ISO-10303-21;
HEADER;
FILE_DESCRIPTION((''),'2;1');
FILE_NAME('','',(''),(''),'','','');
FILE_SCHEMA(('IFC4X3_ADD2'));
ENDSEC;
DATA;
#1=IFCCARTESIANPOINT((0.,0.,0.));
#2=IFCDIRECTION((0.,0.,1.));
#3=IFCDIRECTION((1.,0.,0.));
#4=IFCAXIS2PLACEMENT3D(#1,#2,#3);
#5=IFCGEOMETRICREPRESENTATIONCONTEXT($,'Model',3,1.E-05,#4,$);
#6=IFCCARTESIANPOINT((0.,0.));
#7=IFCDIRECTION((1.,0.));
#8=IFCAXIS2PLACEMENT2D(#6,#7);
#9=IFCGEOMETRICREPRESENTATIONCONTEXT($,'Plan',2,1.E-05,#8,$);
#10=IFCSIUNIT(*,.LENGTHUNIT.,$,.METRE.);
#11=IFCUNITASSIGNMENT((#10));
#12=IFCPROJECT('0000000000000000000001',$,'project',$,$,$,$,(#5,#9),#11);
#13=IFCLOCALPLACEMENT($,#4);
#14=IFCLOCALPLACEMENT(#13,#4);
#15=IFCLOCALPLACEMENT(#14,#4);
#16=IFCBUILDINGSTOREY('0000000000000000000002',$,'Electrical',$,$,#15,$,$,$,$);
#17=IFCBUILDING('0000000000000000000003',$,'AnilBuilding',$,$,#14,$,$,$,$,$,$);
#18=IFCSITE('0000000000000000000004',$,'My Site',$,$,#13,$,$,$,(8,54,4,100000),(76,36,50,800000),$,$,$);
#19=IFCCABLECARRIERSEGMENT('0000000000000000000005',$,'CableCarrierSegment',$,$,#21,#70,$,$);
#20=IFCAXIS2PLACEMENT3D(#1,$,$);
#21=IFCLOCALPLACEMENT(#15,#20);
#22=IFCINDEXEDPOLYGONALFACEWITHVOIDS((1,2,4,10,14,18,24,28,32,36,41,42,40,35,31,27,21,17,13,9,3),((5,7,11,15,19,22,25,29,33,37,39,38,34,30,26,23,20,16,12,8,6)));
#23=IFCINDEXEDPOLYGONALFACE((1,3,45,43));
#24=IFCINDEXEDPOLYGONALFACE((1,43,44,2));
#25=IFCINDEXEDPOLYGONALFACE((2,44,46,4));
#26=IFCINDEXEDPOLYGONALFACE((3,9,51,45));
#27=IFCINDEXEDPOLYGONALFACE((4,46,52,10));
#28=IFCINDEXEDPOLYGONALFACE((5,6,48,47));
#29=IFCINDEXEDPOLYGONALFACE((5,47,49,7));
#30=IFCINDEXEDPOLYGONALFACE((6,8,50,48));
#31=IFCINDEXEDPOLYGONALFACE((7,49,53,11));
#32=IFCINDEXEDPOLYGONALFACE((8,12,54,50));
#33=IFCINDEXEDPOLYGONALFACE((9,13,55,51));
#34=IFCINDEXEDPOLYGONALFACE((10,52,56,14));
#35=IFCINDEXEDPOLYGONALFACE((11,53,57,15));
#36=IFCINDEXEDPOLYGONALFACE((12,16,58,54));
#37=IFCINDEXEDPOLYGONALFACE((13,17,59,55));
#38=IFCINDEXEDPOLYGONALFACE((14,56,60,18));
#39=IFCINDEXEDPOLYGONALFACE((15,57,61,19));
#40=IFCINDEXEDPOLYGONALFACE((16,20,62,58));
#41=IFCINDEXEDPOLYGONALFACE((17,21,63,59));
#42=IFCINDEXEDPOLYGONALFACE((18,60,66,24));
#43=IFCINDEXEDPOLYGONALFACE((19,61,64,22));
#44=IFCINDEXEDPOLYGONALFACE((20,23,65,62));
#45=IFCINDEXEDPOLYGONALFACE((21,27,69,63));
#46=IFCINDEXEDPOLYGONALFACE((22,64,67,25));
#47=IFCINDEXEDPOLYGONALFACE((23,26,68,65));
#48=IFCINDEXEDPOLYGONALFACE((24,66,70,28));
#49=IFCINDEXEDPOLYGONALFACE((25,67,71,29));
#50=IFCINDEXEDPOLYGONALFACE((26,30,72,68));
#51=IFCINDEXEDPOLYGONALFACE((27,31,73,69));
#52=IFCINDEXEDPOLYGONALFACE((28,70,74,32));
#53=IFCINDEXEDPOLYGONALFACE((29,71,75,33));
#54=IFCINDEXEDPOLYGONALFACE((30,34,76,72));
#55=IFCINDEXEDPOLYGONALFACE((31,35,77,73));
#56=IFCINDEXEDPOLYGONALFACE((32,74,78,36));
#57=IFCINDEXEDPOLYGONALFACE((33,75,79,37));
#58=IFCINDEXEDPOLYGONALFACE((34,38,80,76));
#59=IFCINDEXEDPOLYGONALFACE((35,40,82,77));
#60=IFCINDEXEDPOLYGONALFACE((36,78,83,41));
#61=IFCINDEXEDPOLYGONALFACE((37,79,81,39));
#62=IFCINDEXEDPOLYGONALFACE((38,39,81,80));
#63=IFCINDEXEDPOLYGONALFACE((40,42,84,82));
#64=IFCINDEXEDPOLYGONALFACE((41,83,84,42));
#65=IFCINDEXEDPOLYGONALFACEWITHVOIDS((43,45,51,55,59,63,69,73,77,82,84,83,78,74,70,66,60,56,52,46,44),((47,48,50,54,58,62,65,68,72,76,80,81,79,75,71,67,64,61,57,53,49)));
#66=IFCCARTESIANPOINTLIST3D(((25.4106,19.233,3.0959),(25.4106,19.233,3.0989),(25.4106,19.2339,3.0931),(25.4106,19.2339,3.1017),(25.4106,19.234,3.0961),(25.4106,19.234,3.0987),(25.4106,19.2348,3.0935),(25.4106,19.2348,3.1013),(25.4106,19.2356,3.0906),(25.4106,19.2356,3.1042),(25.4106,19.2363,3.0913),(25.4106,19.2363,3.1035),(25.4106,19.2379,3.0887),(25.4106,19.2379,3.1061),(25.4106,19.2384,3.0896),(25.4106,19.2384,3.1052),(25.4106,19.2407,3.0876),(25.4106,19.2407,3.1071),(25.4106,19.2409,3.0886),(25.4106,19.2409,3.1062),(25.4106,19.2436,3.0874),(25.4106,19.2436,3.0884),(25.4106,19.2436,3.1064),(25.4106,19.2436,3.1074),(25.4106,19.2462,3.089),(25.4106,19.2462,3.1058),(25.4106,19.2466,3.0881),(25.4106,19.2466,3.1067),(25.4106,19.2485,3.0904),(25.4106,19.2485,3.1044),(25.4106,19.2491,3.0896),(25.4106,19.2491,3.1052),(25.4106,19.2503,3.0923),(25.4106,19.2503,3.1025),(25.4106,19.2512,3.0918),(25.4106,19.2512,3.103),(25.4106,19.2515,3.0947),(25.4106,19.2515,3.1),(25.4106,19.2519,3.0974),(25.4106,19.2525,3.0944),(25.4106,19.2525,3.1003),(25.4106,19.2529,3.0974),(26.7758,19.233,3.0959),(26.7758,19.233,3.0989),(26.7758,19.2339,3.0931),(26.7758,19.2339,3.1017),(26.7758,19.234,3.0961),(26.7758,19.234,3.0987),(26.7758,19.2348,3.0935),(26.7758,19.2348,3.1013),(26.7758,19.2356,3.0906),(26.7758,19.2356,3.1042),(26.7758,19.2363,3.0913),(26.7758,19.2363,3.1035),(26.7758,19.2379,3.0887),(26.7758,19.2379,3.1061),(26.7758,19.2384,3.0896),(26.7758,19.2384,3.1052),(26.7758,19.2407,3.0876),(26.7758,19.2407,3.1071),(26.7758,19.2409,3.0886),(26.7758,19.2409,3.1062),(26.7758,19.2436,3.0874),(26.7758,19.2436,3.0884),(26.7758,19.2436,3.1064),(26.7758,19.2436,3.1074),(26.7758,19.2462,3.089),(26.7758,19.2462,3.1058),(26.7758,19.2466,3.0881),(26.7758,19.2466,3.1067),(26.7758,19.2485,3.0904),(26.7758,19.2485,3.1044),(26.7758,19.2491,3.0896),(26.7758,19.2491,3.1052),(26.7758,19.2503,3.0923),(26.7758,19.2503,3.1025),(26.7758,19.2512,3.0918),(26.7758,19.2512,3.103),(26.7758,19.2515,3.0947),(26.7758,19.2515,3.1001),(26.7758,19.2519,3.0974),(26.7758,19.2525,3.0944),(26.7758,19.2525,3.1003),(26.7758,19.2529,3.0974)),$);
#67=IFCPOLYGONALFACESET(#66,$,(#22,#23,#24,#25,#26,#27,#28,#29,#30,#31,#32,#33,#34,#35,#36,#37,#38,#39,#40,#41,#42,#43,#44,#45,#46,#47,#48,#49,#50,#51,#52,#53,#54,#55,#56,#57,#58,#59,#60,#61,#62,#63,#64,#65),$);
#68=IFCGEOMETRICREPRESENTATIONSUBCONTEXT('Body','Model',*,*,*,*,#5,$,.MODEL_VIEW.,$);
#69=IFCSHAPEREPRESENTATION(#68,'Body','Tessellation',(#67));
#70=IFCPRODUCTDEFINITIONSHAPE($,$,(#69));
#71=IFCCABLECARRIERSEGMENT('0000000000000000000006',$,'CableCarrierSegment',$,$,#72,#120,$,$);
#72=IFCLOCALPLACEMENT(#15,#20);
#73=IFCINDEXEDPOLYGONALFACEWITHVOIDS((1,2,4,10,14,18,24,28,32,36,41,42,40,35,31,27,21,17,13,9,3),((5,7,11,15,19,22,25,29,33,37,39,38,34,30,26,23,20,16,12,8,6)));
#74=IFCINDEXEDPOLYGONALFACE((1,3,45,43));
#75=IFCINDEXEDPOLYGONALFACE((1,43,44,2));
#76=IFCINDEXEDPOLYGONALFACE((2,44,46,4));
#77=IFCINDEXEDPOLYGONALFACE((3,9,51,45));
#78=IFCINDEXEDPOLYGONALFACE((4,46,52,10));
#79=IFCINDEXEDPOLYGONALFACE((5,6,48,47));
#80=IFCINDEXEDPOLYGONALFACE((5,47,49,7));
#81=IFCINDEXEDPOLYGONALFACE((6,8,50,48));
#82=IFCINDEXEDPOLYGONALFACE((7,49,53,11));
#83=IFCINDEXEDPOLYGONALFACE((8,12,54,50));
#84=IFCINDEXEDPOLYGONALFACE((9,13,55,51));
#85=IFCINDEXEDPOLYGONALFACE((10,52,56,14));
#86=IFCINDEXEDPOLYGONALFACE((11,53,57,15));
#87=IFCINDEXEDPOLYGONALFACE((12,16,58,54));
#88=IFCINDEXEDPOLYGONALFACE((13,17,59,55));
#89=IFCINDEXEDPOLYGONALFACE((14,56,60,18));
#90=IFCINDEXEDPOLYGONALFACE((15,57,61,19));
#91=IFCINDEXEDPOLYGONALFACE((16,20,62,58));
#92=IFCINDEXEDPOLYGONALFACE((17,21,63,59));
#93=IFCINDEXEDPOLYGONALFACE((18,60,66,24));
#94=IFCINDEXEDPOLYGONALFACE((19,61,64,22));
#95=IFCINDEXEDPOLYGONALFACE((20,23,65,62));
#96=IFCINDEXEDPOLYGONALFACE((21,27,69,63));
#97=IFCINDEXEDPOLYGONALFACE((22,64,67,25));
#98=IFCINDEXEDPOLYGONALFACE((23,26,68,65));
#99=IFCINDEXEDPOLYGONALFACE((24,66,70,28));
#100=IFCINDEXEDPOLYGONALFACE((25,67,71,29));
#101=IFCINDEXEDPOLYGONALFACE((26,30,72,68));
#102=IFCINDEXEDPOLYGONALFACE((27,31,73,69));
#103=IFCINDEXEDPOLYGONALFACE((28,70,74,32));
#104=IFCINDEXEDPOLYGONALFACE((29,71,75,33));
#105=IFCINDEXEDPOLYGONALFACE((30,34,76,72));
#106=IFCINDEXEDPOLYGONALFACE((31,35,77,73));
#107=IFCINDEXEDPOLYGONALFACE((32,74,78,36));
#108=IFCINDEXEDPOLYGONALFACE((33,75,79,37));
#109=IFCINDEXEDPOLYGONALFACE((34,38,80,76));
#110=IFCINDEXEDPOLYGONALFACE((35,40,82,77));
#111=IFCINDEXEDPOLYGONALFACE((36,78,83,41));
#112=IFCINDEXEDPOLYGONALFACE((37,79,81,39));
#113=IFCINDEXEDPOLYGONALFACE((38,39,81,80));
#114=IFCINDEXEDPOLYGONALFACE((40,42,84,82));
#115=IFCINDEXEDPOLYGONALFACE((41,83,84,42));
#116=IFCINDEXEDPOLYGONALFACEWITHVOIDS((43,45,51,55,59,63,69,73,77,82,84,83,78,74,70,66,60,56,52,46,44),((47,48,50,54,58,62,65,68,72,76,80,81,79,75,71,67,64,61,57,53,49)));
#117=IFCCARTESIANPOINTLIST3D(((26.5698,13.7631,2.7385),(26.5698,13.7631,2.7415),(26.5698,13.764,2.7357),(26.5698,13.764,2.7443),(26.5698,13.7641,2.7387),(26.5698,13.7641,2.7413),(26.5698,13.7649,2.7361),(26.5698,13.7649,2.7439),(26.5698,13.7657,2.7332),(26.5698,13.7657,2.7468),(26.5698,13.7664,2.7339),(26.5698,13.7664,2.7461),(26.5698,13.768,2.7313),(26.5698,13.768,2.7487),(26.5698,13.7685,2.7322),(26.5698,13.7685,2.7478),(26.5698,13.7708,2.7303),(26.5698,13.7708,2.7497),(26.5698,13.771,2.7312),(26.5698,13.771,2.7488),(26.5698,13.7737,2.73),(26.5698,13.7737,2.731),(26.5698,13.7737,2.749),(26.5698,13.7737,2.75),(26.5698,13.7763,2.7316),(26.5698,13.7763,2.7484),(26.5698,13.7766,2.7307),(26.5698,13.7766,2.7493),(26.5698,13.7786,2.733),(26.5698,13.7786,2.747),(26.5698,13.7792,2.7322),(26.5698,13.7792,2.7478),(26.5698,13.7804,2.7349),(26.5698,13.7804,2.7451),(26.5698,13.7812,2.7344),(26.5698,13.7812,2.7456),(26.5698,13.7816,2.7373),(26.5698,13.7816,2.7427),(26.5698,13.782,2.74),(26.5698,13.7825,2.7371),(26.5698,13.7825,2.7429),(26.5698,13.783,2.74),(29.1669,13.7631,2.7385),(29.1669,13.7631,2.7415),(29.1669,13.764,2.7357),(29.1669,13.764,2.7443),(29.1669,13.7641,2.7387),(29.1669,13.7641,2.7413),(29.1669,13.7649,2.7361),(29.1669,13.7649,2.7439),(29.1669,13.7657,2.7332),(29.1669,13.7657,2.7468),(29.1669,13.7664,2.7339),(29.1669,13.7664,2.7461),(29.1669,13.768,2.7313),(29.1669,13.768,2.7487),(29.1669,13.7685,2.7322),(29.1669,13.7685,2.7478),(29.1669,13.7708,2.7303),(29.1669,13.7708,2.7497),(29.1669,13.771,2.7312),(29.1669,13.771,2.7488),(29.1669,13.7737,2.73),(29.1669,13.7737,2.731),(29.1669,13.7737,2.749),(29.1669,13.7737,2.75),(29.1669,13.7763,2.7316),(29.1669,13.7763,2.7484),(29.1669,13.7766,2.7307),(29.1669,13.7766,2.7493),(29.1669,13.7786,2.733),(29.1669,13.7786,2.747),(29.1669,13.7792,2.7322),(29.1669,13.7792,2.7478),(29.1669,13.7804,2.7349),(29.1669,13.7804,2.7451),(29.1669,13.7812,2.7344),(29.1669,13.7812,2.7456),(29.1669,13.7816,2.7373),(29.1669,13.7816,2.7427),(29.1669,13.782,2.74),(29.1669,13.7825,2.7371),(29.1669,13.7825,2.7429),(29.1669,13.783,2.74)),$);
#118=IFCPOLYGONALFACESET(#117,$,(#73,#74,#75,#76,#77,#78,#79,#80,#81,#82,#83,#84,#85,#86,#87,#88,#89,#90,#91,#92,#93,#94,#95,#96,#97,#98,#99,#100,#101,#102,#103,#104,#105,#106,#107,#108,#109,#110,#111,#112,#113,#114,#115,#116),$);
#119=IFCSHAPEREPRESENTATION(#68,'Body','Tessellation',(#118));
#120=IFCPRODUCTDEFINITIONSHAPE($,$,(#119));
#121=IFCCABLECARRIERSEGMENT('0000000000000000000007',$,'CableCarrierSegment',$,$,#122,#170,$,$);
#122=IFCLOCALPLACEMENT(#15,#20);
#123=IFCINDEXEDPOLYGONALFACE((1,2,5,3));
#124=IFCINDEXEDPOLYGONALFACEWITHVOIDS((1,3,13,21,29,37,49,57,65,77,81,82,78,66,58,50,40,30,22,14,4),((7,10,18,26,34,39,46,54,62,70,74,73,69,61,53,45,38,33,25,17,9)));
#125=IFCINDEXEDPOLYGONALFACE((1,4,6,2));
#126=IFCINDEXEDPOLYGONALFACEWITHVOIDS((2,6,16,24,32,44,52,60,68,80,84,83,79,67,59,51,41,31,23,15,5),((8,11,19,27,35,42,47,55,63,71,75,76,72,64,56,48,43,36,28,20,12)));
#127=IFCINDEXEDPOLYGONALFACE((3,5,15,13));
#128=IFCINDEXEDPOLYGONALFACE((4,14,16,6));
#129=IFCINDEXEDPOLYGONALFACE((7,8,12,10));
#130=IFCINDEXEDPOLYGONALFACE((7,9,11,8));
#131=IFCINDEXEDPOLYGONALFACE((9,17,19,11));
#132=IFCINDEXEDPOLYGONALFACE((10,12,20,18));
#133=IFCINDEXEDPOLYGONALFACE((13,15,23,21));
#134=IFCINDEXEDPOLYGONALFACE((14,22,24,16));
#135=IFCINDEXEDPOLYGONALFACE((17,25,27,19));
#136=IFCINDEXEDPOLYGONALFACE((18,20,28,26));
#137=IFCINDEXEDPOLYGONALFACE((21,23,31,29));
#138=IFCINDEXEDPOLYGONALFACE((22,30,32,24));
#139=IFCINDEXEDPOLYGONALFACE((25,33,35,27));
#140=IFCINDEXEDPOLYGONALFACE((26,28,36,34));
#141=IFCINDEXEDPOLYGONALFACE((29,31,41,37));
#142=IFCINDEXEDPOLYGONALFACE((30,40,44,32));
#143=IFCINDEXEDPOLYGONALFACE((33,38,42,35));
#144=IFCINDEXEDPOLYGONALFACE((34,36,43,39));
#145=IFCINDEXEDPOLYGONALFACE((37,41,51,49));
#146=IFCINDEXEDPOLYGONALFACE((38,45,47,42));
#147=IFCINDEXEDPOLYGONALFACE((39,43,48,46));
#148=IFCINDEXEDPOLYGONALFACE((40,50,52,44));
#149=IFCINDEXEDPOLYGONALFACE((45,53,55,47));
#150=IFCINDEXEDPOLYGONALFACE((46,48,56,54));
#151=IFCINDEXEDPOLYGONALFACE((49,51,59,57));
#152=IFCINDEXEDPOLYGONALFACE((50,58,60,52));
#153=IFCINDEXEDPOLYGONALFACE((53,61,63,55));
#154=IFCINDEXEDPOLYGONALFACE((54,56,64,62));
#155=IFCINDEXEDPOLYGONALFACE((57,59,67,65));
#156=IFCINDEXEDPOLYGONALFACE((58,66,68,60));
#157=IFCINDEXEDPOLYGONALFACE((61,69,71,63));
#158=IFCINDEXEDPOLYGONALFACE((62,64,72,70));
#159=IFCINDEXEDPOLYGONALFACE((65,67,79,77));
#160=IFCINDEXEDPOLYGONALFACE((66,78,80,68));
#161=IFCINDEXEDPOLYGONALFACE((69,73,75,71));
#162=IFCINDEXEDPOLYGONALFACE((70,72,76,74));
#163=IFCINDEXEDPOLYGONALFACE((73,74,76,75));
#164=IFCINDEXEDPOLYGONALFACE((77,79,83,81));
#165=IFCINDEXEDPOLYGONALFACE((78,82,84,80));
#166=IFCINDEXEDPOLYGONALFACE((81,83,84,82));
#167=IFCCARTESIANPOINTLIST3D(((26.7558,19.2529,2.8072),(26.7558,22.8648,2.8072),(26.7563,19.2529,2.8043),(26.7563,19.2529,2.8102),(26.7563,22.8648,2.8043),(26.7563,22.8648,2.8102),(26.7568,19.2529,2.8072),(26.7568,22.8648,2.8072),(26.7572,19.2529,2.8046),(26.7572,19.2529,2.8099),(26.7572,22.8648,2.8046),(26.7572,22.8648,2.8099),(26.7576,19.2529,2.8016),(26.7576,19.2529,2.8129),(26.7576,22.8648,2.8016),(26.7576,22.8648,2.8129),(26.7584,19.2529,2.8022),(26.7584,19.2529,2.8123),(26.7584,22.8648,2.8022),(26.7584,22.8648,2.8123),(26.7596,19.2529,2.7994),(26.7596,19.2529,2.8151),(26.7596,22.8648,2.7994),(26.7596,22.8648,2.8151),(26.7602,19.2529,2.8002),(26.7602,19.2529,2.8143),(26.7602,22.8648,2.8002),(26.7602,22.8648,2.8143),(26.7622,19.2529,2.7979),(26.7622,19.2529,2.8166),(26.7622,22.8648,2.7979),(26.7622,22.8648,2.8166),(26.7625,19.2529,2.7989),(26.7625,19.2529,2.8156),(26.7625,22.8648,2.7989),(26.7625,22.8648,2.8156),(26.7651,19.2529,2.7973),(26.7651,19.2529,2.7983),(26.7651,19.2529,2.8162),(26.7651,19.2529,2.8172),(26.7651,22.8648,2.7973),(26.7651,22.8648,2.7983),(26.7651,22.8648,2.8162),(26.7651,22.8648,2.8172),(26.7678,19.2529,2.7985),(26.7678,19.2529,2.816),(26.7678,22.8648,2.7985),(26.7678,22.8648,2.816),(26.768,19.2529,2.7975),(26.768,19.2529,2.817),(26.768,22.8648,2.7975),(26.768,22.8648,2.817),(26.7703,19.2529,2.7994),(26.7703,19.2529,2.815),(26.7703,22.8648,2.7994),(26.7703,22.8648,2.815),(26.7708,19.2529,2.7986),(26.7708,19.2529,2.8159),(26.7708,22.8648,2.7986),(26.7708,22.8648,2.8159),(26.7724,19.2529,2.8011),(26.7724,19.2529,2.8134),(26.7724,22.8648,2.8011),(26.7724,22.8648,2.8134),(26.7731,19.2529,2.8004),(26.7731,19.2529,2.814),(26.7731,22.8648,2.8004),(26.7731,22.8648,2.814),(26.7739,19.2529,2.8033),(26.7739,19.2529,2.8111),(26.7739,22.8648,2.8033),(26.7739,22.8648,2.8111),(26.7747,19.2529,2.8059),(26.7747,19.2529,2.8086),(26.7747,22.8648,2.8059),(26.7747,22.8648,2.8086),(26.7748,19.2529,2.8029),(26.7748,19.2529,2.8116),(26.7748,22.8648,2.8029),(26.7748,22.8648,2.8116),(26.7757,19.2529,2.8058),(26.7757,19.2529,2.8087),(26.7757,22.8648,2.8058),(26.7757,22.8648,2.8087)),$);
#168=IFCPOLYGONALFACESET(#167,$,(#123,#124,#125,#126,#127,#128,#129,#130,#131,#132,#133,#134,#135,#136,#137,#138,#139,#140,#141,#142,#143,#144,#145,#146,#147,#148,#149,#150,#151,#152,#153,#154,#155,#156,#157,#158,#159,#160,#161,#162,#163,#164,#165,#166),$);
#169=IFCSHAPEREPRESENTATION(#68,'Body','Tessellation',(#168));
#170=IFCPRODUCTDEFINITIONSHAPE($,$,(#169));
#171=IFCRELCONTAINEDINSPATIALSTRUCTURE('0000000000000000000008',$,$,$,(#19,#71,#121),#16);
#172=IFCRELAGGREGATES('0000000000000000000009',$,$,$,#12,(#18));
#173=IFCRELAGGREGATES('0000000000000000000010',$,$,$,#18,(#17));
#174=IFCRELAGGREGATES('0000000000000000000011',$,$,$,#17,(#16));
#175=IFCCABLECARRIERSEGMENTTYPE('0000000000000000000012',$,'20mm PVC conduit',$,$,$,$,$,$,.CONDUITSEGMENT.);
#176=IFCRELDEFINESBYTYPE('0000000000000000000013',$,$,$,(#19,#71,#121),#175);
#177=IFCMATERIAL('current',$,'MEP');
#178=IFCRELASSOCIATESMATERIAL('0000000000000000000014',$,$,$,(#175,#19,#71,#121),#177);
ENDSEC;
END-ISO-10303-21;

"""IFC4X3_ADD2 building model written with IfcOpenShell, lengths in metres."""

from ifc_helpers import new_model, si_unit, frame, origin_with_axes, origin_2d_with_axis, place, context, subcontext, project, spatial, hollow_circle, extrude, material, material_profile, profile_set, profile_usage, type_object, element, save


model = new_model("IFC4X3_ADD2")

# Units and contexts
model_context = context("Model", 3, precision=1e-05, world=origin_with_axes())
plan_context = context("Plan", 2, precision=1e-05, world=origin_2d_with_axis())
body_context = subcontext(model_context, "Body", "Model", "MODEL_VIEW")
ifc_project = project(units=[si_unit("LENGTHUNIT", "METRE")], contexts=[model_context, plan_context])

# Site, building, storey
site_placement = place(None, origin_with_axes())
site = spatial("IfcSite", under=ifc_project, at=site_placement, Name="My Site", RefLatitude=(8, 54, 4, 100000), RefLongitude=(76, 36, 50, 800000))
building_placement = place(site_placement, origin_with_axes())
building = spatial("IfcBuilding", under=site, at=building_placement, Name="AnilBuilding")
storey_placement = place(building_placement, origin_with_axes())
storey = spatial("IfcBuildingStorey", under=building, at=storey_placement, Name="Electrical")

# Cable carrier segments
ifc_material = material(Name="current", Category="MEP")
ifc_material_profile_1 = material_profile(ifc_material, hollow_circle(Radius=0.01, WallThickness=0.001))
ifc_profile_set_1 = profile_set([ifc_material_profile_1], Name="current")
ifc_material_profile_2 = material_profile(ifc_material, hollow_circle(Radius=0.01, WallThickness=0.001))
ifc_profile_set_2 = profile_set([ifc_material_profile_2], Name="current")
cable_carrier_segment_type = type_object("IfcCableCarrierSegmentType", Name="20mm PVC conduit", PredefinedType="CONDUITSEGMENT", material=ifc_profile_set_2)
ifc_profile_usage_1 = profile_usage(ifc_profile_set_1, cardinal=5)
cable_carrier_segment_1_placement = place(storey_placement, frame((25.4106, 19.2429, 3.0974), z_axis=(1.0, -0.000001, 0.0), x_axis=(0.000001, 1.0, 0.0)))
element("IfcCableCarrierSegment", 1, at=cable_carrier_segment_1_placement, inside=storey, type_object=cable_carrier_segment_type, material=ifc_profile_usage_1, Name="CableCarrierSegment", context=body_context, shape_type="SweptSolid", body=[
    extrude(hollow_circle(Radius=0.01, WallThickness=0.001), origin_with_axes(), (0.0, 0.0, 1.0), 1.3652),
])
ifc_profile_usage_2 = profile_usage(ifc_profile_set_1, cardinal=5)
cable_carrier_segment_2_placement = place(storey_placement, frame((26.5698, 13.773, 2.74), z_axis=(1.0, 0.0, 0.0), x_axis=(0.0, 1.0, 0.0)))
element("IfcCableCarrierSegment", 2, at=cable_carrier_segment_2_placement, inside=storey, type_object=cable_carrier_segment_type, material=ifc_profile_usage_2, Name="CableCarrierSegment", context=body_context, shape_type="SweptSolid", body=[
    extrude(hollow_circle(Radius=0.01, WallThickness=0.001), origin_with_axes(), (0.0, 0.0, 1.0), 2.5971),
])
ifc_profile_usage_3 = profile_usage(ifc_profile_set_1, cardinal=5)
cable_carrier_segment_3_placement = place(storey_placement, frame((26.7658, 19.2529, 2.8072), z_axis=(0.0, 1.0, 0.0), x_axis=(-1.0, 0.0, 0.0)))
element("IfcCableCarrierSegment", 3, at=cable_carrier_segment_3_placement, inside=storey, type_object=cable_carrier_segment_type, material=ifc_profile_usage_3, Name="CableCarrierSegment", context=body_context, shape_type="SweptSolid", body=[
    extrude(hollow_circle(Radius=0.01, WallThickness=0.001), origin_with_axes(), (0.0, 0.0, 1.0), 3.6119),
])

save(model, "model.ifc")
